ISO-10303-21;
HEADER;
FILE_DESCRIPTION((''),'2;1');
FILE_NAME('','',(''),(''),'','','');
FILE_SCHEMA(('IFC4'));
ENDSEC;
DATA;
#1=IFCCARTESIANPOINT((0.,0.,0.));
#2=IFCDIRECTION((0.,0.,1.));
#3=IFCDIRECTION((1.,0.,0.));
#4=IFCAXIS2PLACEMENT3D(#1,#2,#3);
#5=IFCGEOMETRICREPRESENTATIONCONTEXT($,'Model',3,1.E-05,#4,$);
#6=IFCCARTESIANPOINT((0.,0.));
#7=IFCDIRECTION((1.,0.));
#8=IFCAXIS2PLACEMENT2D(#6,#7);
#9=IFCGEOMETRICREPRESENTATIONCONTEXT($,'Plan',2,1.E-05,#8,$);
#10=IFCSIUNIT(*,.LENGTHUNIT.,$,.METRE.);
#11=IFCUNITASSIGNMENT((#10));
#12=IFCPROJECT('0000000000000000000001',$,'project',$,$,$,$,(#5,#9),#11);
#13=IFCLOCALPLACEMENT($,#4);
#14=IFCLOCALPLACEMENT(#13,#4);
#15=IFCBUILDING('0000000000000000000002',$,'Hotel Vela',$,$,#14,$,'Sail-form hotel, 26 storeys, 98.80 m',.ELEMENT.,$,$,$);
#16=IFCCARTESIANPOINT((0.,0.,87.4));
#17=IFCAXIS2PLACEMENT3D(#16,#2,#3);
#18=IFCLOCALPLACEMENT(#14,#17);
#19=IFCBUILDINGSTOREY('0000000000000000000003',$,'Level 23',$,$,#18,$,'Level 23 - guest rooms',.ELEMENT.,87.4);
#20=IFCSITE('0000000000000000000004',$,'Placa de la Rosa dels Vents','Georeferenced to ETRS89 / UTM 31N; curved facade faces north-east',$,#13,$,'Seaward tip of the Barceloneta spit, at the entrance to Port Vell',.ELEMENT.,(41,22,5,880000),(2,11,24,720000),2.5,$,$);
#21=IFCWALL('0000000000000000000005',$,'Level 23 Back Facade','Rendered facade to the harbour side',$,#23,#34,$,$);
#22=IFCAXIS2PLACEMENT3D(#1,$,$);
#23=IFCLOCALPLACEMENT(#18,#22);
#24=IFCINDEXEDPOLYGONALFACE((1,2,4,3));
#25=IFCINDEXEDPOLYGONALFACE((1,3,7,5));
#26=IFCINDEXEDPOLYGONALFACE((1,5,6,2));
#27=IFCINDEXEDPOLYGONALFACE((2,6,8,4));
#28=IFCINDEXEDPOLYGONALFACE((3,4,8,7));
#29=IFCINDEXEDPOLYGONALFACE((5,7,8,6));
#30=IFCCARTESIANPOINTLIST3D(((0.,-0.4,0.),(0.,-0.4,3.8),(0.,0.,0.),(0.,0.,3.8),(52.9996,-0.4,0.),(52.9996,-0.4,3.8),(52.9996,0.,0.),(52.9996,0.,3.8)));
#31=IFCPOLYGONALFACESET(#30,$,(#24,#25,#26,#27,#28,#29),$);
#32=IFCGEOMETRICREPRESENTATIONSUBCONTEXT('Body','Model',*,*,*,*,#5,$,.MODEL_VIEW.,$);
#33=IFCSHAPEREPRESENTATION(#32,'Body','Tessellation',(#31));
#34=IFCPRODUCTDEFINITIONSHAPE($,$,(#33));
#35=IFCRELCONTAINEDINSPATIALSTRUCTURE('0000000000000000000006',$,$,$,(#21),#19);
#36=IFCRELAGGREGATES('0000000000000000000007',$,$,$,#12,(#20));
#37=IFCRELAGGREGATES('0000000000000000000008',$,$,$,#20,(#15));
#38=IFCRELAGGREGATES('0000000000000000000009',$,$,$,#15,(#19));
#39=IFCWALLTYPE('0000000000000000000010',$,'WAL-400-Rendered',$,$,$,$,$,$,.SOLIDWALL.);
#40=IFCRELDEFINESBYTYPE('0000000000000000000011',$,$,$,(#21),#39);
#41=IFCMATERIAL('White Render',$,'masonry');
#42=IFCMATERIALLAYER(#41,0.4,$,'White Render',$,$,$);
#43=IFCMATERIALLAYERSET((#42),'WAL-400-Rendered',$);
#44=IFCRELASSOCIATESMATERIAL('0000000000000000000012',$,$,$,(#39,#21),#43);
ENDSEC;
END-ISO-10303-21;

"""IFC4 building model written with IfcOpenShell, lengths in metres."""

from ifc_helpers import new_model, si_unit, frame, origin_with_axes, origin_2d_with_axis, place, context, subcontext, project, spatial, line, indexed_curve, outline, extrude, material, layer, layer_set, layer_usage, type_object, element, save


model = new_model("IFC4")

# Units and contexts
model_context = context("Model", 3, precision=1e-05, world=origin_with_axes())
plan_context = context("Plan", 2, precision=1e-05, world=origin_2d_with_axis())
body_context = subcontext(model_context, "Body", "Model", "MODEL_VIEW")
ifc_project = project(units=[si_unit("LENGTHUNIT", "METRE")], contexts=[model_context, plan_context])

# Site, building, storey
site_placement = place(None, origin_with_axes())
site = spatial("IfcSite", under=ifc_project, at=site_placement, Name="Placa de la Rosa dels Vents", Description="Georeferenced to ETRS89 / UTM 31N; curved facade faces north-east", LongName="Seaward tip of the Barceloneta spit, at the entrance to Port Vell", CompositionType="ELEMENT", RefLatitude=(41, 22, 5, 880000), RefLongitude=(2, 11, 24, 720000), RefElevation=2.5)
building_placement = place(site_placement, origin_with_axes())
building = spatial("IfcBuilding", under=site, at=building_placement, Name="Hotel Vela", LongName="Sail-form hotel, 26 storeys, 98.80 m", CompositionType="ELEMENT")
storey_placement = place(building_placement, frame((0.0, 0.0, 87.4), z_axis=(0.0, 0.0, 1.0), x_axis=(1.0, 0.0, 0.0)))
storey = spatial("IfcBuildingStorey", under=building, at=storey_placement, Name="Level 23", LongName="Level 23 - guest rooms", CompositionType="ELEMENT", Elevation=87.4)

# Wall
ifc_material_1 = material(Name="White Render", Category="masonry")
ifc_layer_1 = layer(ifc_material_1, 0.4, Name="White Render")
ifc_layer_set_1 = layer_set([ifc_layer_1], Name="WAL-400-Rendered")
ifc_layer_usage_1 = layer_usage(ifc_layer_set_1, "AXIS2", "POSITIVE", 0.0)
wall_type = type_object("IfcWallType", Name="WAL-400-Rendered", PredefinedType="SOLIDWALL", material=ifc_layer_set_1)
wall_placement = place(storey_placement, frame((0.0, -0.4, 0.0), z_axis=(0.0, 0.0, 1.0), x_axis=(1.0, 0.0, 0.0)))
element("IfcWall", 1, at=wall_placement, inside=storey, type_object=wall_type, material=ifc_layer_usage_1, Name="Level 23 Back Facade", Description="Rendered facade to the harbour side", context=body_context, shape_type="SweptSolid", body=[
    extrude(outline(indexed_curve([(0.0, 0.0), (52.9996, 0.0), (52.9996, 0.4), (0.0, 0.4)], segments=[line(1, 2, 3, 4, 1)])), origin_with_axes(), (0.0, 0.0, 1.0), 3.8),
])

save(model, "model.ifc")
